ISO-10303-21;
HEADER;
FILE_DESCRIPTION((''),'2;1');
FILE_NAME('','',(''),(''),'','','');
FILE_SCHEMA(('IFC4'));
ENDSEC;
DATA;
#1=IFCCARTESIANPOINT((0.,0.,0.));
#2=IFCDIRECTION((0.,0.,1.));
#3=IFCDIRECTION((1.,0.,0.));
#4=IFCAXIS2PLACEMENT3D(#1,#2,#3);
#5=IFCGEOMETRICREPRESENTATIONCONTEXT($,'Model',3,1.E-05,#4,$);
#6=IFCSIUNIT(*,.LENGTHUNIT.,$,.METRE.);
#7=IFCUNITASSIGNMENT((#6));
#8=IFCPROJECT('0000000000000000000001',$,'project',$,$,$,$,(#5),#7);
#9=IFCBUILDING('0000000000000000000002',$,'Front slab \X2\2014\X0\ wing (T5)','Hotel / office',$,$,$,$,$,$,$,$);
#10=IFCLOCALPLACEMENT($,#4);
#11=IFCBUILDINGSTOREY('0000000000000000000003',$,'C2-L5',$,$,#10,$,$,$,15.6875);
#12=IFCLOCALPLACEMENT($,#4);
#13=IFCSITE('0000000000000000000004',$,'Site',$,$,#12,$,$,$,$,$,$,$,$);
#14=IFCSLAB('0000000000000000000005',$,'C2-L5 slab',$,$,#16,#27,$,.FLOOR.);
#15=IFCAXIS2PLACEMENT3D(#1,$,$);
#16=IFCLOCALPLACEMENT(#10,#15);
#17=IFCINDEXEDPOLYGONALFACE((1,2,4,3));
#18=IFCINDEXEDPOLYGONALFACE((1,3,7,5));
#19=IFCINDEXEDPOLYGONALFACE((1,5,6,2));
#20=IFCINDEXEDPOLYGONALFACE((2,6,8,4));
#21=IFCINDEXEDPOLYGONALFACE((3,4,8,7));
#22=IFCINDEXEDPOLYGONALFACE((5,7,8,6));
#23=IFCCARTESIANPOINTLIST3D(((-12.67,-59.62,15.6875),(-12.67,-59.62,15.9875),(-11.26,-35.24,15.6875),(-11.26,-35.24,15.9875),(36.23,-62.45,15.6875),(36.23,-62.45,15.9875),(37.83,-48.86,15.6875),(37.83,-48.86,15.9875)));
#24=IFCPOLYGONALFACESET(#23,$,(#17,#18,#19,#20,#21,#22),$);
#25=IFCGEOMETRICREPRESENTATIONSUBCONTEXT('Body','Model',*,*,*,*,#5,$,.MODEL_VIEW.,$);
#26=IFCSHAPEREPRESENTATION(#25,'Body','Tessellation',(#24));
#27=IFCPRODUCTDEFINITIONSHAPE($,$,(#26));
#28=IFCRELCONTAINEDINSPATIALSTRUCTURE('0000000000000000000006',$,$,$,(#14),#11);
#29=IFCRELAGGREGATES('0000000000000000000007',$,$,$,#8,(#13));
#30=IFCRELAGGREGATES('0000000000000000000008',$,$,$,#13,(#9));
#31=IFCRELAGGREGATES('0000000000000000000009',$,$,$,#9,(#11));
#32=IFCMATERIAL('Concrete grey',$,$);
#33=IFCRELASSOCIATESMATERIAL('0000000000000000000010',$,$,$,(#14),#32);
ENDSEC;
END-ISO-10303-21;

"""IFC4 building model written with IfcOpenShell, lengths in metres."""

from ifc_helpers import new_model, si_unit, frame, origin_with_axes, place, context, subcontext, project, spatial, polyline, outline, extrude, material, element, save


model = new_model("IFC4")

# Units and contexts
model_context = context("Model", 3, precision=1e-05, world=origin_with_axes())
body_context = subcontext(model_context, "Body", "Model", "MODEL_VIEW")
ifc_project = project(units=[si_unit("LENGTHUNIT", "METRE")], contexts=[model_context])

# Site, building, storey
site_placement = place(None, origin_with_axes())
site = spatial("IfcSite", under=ifc_project, at=site_placement, Name="Site")
building = spatial("IfcBuilding", under=site, Name="Front slab — wing (T5)", Description="Hotel / office")
storey_placement = place(None, origin_with_axes())
storey = spatial("IfcBuildingStorey", under=building, at=storey_placement, Name="C2-L5", Elevation=15.6875)

# Slab
ifc_material_1 = material(Name="Concrete grey")
slab_placement = place(storey_placement, origin_with_axes())
element("IfcSlab", 1, at=slab_placement, inside=storey, material=ifc_material_1, Name="C2-L5 slab", PredefinedType="FLOOR", context=body_context, shape_type="SweptSolid", body=[
    extrude(outline(polyline([(-11.26, -35.24), (-12.67, -59.62), (36.23, -62.45), (37.83, -48.86), (-11.26, -35.24)])), frame((0.0, 0.0, 15.6875), z_axis=(0.0, 0.0, 1.0), x_axis=(1.0, 0.0, 0.0)), (0.0, 0.0, 1.0), 0.3),
])

save(model, "model.ifc")
